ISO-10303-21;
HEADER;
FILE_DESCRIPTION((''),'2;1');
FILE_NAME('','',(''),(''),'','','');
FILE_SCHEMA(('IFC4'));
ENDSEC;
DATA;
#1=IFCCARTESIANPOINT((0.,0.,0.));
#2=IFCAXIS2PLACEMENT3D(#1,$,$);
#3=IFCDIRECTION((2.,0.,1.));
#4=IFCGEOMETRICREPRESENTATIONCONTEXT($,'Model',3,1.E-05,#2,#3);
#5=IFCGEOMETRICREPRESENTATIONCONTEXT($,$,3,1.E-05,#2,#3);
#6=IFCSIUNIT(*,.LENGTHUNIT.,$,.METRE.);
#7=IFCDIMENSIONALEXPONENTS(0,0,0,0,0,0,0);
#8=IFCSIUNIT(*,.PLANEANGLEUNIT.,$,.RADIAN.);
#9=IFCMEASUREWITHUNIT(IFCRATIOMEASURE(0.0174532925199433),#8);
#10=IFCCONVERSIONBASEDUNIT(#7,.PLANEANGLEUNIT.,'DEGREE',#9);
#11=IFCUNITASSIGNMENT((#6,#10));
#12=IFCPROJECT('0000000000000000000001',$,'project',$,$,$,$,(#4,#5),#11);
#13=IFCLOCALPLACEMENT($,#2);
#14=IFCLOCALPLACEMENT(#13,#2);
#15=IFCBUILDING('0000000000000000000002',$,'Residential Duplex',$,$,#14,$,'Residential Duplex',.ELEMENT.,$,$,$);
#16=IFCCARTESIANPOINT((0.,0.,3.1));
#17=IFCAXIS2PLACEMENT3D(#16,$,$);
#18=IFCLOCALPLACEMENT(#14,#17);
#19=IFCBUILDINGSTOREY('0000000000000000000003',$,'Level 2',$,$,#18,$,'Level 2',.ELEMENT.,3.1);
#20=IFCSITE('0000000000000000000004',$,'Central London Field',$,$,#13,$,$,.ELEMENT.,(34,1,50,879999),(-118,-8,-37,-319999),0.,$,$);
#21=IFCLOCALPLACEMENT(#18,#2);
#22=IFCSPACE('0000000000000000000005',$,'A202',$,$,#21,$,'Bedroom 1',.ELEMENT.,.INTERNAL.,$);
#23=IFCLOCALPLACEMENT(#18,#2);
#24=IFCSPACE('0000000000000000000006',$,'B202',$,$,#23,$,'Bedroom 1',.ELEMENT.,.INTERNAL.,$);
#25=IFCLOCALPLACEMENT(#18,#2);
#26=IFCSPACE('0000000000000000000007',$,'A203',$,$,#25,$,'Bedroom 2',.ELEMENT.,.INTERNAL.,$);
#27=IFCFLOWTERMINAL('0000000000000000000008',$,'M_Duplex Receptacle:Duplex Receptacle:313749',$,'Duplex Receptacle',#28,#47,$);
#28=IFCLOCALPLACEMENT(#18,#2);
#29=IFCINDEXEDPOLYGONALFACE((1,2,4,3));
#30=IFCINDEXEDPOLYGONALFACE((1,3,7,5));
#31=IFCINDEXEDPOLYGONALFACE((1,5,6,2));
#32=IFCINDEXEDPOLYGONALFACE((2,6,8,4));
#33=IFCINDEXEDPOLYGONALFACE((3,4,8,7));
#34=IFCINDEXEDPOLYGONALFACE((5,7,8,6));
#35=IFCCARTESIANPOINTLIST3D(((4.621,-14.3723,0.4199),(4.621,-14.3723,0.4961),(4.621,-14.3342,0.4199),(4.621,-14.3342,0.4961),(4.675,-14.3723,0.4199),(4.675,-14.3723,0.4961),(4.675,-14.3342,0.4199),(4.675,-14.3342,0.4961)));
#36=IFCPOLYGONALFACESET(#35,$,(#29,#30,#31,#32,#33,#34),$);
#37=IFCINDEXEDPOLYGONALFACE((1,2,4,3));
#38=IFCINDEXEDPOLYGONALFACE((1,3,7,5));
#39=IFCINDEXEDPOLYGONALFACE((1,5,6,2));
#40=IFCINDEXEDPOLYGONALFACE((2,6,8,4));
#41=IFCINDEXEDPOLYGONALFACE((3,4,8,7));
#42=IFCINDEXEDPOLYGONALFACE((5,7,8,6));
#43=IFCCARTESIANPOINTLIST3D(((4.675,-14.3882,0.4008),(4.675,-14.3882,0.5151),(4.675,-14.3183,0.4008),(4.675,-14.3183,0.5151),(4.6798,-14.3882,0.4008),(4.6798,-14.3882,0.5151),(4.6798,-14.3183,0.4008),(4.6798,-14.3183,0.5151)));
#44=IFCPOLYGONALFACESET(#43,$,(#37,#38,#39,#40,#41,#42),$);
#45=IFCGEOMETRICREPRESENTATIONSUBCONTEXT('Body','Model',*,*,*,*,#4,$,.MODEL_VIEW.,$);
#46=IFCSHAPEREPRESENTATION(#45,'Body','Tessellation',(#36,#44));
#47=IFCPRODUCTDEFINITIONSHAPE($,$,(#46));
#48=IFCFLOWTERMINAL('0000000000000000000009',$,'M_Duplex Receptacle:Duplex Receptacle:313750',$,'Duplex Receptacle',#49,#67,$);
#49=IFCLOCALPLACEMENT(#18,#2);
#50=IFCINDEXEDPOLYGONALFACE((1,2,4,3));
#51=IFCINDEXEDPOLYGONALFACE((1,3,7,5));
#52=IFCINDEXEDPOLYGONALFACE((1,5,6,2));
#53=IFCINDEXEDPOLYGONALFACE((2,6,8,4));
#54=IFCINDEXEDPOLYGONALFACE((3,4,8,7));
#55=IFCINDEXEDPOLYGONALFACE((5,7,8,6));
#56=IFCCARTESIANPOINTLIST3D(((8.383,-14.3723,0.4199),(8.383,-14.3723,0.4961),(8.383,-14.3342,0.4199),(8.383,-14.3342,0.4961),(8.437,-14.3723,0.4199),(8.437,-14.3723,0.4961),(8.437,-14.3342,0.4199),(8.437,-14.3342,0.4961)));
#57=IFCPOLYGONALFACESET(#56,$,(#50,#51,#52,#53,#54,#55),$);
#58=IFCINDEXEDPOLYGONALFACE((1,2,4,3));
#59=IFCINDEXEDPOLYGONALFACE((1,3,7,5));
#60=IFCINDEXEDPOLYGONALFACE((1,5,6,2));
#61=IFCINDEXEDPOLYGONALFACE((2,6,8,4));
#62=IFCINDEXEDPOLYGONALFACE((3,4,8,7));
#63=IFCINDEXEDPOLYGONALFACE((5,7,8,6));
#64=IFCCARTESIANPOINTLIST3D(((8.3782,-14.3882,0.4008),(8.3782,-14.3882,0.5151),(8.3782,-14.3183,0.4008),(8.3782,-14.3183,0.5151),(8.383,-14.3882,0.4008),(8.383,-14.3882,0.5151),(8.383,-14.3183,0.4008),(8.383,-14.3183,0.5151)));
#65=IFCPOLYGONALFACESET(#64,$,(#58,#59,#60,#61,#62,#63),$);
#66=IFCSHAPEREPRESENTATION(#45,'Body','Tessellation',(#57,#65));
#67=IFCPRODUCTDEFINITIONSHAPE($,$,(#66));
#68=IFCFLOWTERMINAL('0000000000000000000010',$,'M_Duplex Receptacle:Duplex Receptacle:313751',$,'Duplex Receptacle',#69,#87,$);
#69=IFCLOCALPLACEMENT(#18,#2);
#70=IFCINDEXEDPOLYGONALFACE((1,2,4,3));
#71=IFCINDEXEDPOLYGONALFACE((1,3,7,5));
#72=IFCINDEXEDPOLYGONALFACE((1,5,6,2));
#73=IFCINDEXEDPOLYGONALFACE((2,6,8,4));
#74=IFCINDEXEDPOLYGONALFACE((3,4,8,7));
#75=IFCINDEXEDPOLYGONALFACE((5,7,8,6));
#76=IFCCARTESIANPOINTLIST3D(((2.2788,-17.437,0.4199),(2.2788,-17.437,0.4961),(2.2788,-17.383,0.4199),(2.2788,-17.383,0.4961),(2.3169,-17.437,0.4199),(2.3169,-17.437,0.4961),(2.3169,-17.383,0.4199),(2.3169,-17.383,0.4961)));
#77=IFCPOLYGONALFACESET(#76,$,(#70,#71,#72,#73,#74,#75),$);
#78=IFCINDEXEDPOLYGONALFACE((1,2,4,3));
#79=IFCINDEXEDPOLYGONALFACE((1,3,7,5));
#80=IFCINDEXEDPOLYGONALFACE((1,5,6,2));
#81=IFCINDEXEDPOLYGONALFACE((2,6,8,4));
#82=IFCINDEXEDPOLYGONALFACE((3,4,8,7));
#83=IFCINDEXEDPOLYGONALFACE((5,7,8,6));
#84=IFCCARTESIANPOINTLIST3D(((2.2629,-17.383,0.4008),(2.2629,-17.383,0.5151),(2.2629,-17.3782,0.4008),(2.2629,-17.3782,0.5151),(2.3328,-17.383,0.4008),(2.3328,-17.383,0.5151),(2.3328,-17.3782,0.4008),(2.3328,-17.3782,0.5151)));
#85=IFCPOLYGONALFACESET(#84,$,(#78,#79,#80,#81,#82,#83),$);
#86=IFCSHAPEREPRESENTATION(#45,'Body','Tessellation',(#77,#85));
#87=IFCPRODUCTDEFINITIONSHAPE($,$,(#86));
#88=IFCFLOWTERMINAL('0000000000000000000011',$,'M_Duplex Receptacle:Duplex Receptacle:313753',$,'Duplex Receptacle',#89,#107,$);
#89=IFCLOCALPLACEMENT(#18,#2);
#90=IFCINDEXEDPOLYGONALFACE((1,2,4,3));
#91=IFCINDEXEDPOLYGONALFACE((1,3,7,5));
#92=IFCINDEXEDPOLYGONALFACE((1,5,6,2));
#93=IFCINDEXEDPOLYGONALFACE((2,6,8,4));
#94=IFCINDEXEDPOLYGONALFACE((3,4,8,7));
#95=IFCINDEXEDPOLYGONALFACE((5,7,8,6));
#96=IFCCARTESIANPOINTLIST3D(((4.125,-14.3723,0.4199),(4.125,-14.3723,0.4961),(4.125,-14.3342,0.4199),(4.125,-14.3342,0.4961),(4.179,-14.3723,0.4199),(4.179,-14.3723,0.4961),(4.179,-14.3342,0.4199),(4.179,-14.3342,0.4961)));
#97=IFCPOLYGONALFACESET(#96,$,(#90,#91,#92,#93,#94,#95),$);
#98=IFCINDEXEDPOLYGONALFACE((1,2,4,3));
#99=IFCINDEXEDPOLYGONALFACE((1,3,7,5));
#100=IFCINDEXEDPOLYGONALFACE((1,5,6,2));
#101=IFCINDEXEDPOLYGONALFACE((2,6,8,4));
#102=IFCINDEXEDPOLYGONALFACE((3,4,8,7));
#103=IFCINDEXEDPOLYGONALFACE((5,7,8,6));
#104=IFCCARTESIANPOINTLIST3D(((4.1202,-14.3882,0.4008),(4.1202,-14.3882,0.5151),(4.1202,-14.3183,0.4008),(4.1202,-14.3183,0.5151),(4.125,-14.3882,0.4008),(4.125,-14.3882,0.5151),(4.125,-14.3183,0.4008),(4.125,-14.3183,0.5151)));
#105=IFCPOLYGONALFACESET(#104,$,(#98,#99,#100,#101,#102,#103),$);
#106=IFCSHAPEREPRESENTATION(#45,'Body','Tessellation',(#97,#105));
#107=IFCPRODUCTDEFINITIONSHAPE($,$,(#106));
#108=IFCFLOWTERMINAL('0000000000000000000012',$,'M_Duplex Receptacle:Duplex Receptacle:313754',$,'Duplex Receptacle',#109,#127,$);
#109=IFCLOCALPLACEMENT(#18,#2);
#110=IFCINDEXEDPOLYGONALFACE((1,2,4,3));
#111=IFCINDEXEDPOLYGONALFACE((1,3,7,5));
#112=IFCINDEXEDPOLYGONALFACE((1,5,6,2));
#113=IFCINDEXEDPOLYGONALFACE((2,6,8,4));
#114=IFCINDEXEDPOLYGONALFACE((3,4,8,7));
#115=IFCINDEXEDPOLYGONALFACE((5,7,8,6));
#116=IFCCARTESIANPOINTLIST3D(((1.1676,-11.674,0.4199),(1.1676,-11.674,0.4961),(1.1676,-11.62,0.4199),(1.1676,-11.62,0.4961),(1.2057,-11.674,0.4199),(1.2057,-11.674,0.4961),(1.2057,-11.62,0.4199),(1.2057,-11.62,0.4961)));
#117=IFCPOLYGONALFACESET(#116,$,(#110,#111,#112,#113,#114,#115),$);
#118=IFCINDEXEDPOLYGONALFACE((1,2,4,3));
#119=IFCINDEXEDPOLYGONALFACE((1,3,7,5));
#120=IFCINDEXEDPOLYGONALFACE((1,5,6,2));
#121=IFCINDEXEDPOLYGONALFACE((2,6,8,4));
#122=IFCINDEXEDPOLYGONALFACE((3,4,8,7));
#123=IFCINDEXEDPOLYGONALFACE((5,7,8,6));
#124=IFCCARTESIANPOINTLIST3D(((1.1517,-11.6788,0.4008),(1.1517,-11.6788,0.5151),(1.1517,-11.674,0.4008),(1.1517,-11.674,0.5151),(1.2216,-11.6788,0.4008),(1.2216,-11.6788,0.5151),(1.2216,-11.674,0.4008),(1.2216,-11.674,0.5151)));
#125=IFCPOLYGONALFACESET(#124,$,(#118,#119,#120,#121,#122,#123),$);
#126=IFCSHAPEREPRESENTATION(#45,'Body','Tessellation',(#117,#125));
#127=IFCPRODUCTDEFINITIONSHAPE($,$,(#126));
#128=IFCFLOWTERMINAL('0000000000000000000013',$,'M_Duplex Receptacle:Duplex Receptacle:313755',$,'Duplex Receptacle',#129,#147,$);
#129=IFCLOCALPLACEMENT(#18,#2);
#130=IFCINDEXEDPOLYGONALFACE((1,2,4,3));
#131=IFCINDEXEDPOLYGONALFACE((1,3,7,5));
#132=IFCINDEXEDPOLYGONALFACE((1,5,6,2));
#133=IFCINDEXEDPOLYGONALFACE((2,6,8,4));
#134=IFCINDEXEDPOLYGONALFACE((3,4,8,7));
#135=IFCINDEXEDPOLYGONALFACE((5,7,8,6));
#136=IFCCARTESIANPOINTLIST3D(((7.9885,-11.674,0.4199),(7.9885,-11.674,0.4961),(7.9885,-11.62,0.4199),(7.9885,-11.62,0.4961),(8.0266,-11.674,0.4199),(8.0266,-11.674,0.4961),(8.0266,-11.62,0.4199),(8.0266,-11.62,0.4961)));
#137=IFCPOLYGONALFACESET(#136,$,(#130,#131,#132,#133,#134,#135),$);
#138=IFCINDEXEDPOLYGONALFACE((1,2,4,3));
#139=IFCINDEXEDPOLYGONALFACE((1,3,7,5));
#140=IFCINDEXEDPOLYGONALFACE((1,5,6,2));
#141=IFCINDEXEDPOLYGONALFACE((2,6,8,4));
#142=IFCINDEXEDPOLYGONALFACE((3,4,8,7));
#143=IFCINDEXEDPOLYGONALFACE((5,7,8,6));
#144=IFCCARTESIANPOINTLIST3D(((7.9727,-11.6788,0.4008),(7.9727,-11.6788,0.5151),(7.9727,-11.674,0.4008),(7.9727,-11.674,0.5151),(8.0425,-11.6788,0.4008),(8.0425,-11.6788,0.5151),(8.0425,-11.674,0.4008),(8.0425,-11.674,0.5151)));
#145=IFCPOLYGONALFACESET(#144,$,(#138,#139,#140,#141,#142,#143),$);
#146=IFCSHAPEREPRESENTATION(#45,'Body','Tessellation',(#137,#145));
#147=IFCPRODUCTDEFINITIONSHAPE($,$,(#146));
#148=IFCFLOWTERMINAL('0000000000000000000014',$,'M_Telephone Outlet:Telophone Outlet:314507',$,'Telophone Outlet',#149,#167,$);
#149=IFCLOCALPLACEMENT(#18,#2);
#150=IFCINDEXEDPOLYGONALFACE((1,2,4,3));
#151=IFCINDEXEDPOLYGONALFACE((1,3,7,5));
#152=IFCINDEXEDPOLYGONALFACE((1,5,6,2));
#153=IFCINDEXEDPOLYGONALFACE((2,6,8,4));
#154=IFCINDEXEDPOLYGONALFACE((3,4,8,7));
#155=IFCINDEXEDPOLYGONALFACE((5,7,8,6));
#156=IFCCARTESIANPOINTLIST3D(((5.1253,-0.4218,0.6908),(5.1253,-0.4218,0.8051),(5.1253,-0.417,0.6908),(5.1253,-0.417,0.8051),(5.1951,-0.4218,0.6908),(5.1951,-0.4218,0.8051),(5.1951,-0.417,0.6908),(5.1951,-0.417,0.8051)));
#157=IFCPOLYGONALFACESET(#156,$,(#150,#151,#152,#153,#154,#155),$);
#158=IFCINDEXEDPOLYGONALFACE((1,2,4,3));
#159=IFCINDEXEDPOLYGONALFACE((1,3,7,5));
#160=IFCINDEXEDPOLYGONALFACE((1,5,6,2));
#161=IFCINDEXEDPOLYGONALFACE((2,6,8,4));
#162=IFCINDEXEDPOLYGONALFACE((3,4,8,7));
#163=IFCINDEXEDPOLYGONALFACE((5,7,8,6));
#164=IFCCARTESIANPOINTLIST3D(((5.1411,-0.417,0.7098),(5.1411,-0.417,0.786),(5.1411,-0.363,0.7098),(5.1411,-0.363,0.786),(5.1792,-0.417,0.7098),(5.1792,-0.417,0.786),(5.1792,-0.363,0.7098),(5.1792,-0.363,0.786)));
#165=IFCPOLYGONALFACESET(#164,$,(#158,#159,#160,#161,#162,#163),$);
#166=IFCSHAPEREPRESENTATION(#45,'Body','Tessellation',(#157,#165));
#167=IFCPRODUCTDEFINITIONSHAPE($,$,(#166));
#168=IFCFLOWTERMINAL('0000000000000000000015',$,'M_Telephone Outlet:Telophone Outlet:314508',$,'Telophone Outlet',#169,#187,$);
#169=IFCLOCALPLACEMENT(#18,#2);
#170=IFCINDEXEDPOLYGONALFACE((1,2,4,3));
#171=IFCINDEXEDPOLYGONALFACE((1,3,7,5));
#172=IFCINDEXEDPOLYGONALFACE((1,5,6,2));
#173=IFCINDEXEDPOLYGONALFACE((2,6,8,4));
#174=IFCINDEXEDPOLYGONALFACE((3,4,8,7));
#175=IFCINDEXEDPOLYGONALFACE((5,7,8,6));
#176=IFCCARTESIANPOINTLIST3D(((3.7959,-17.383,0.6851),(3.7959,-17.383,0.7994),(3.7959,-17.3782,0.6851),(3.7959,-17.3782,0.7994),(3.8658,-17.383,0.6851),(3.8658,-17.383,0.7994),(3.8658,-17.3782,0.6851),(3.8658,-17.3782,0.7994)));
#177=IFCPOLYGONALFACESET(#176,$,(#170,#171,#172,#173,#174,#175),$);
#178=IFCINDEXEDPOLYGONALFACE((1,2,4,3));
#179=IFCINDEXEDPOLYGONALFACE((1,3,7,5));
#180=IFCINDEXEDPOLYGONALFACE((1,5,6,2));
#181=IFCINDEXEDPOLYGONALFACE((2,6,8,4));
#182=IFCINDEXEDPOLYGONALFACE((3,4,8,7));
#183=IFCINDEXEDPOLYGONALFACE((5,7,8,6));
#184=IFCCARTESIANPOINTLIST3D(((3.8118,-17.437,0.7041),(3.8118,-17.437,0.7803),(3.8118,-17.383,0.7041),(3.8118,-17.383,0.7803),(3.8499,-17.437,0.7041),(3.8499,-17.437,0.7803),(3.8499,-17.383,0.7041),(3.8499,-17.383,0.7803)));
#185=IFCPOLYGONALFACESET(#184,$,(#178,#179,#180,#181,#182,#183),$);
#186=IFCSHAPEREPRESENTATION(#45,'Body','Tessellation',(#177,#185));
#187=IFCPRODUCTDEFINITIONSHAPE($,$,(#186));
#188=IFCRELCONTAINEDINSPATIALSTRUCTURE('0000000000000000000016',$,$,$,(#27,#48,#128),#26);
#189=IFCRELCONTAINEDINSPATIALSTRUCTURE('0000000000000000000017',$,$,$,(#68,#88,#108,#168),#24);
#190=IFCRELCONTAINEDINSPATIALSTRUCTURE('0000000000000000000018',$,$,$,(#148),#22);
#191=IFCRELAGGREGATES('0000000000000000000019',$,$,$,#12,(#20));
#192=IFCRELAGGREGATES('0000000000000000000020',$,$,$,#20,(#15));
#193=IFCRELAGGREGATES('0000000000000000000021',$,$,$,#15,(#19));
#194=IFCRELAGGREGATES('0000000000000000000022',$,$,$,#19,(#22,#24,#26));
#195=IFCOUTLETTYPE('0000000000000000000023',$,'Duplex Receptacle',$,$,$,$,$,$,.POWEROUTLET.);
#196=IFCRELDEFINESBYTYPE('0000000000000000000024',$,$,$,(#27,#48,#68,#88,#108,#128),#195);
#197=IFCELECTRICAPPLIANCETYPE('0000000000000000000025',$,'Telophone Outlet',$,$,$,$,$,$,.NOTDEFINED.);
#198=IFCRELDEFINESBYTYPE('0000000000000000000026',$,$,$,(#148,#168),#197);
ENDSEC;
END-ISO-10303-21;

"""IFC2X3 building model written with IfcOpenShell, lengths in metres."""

from ifc_helpers import new_model, entity, si_unit, converted_unit, direction, frame, frame_2d, origin, origin_2d_with_axis, place, context, subcontext, project, spatial, rectangle, extrude, source, transform, mapped, type_object, type_shapes, element, save


model = new_model("IFC2X3")

# Units and contexts
model_context = context("Model", 3, precision=1e-05, world=origin(), true_north=direction((2.0, 0.0, 1.0)))
context_of_model = context(None, 3, precision=1e-05, world=origin(), true_north=direction((2.0, 0.0, 1.0)))
body_context = subcontext(model_context, "Body", "Model", "MODEL_VIEW")
ifc_project = project(units=[si_unit("LENGTHUNIT", "METRE"), converted_unit("PLANEANGLEUNIT", "DEGREE", entity("IfcRatioMeasure", 0.0174532925199433), si_unit("PLANEANGLEUNIT", "RADIAN"), dimensions=[0, 0, 0, 0, 0, 0, 0])], contexts=[model_context, context_of_model])

# Site, building, storey, space
site_placement = place(None, origin())
site = spatial("IfcSite", under=ifc_project, at=site_placement, Name="Central London Field", CompositionType="ELEMENT", RefLatitude=(34, 1, 50, 879999), RefLongitude=(-118, -8, -37, -319999), RefElevation=0.0)
building_placement = place(site_placement, origin())
building = spatial("IfcBuilding", under=site, at=building_placement, Name="Residential Duplex", LongName="Residential Duplex", CompositionType="ELEMENT")
storey_placement = place(building_placement, frame((0.0, 0.0, 3.1)))
storey = spatial("IfcBuildingStorey", under=building, at=storey_placement, Name="Level 2", LongName="Level 2", CompositionType="ELEMENT", Elevation=3.1)
space_1_placement = place(storey_placement, origin())
space_1 = spatial("IfcSpace", under=storey, at=space_1_placement, Name="A202", LongName="Bedroom 1", CompositionType="ELEMENT", InteriorOrExteriorSpace="INTERNAL")

# Shared definitions
space_2_placement = place(storey_placement, origin())
space_2 = spatial("IfcSpace", under=storey, at=space_2_placement, Name="B202", LongName="Bedroom 1", CompositionType="ELEMENT", InteriorOrExteriorSpace="INTERNAL")

# Shared definitions
space_3_placement = place(storey_placement, origin())
space_3 = spatial("IfcSpace", under=storey, at=space_3_placement, Name="A203", LongName="Bedroom 2", CompositionType="ELEMENT", InteriorOrExteriorSpace="INTERNAL")

# Flow terminals
outlet_type = type_object("IfcOutletType", Name="Duplex Receptacle", PredefinedType="POWEROUTLET")
shared_shape_1 = source(origin(), body_context, "Body", "SweptSolid", [
    extrude(rectangle(XDim=0.0381, YDim=0.0762, at=origin_2d_with_axis()), frame((0.0, 0.0, -0.054), z_axis=(0.0, 0.0, 1.0), x_axis=(-1.0, 0.0, 0.0)), (0.0, 0.0, 1.0), 0.054),
    extrude(rectangle(XDim=0.0698, YDim=0.1143, at=frame_2d((0.0, 0.0), x_axis=(1.0, 0.0))), frame((0.0, 0.0, 0.0), z_axis=(0.0, 0.0, 1.0), x_axis=(-1.0, 0.0, 0.0)), (0.0, 0.0, 1.0), 0.0048),
])
type_shapes(outlet_type, [shared_shape_1])
for number, where, z_axis, x_axis, name in (
    (1, (4.675, -14.3533, 0.458), (1.0, 0.0, 0.0), (0.0, 1.0, 0.0), "M_Duplex Receptacle:Duplex Receptacle:313749"),
    (2, (8.383, -14.3533, 0.458), (-1.0, 0.0, 0.0), (0.0, -1.0, 0.0), "M_Duplex Receptacle:Duplex Receptacle:313750"),
):
    element("IfcFlowTerminal", number, at=place(space_3_placement, frame(where, z_axis=z_axis, x_axis=x_axis)), inside=space_3, type_object=outlet_type, Name=name, ObjectType="Duplex Receptacle", context=body_context, shape_type="MappedRepresentation", body=[
        mapped(shared_shape_1, transform((0.0, 0.0, 0.0), scale=1.0)),
    ])
for number, where, z_axis, x_axis, name in (
    (3, (2.2979, -17.383, 0.458), (0.0, 1.0, 0.0), (-1.0, 0.0, 0.0), "M_Duplex Receptacle:Duplex Receptacle:313751"),
    (4, (4.125, -14.3533, 0.458), (-1.0, 0.0, 0.0), (0.0, -1.0, 0.0), "M_Duplex Receptacle:Duplex Receptacle:313753"),
    (5, (1.1866, -11.674, 0.458), (0.0, -1.0, 0.0), (1.0, 0.0, 0.0), "M_Duplex Receptacle:Duplex Receptacle:313754"),
):
    element("IfcFlowTerminal", number, at=place(space_2_placement, frame(where, z_axis=z_axis, x_axis=x_axis)), inside=space_2, type_object=outlet_type, Name=name, ObjectType="Duplex Receptacle", context=body_context, shape_type="MappedRepresentation", body=[
        mapped(shared_shape_1, transform((0.0, 0.0, 0.0), scale=1.0)),
    ])
flow_terminal_1_placement = place(space_3_placement, frame((8.0076, -11.674, 0.458), z_axis=(0.0, -1.0, 0.0), x_axis=(1.0, 0.0, 0.0)))
element("IfcFlowTerminal", 6, at=flow_terminal_1_placement, inside=space_3, type_object=outlet_type, Name="M_Duplex Receptacle:Duplex Receptacle:313755", ObjectType="Duplex Receptacle", context=body_context, shape_type="MappedRepresentation", body=[
    mapped(shared_shape_1, transform((0.0, 0.0, 0.0), scale=1.0)),
])
electric_appliance_type = type_object("IfcElectricApplianceType", Name="Telophone Outlet", PredefinedType="NOTDEFINED")
shared_shape_2 = source(origin(), body_context, "Body", "SweptSolid", [
    extrude(rectangle(XDim=0.0699, YDim=0.1143, at=frame_2d((0.0, 0.0), x_axis=(1.0, 0.0))), frame((0.0, 0.0, 0.0), z_axis=(0.0, 0.0, 1.0), x_axis=(-1.0, 0.0, 0.0)), (0.0, 0.0, 1.0), 0.0048),
    extrude(rectangle(XDim=0.0381, YDim=0.0762, at=origin_2d_with_axis()), frame((0.0, 0.0, -0.054), z_axis=(0.0, 0.0, 1.0), x_axis=(-1.0, 0.0, 0.0)), (0.0, 0.0, 1.0), 0.054),
])
type_shapes(electric_appliance_type, [shared_shape_2])
flow_terminal_2_placement = place(space_1_placement, frame((5.1602, -0.417, 0.7479), z_axis=(0.0, -1.0, 0.0), x_axis=(1.0, 0.0, 0.0)))
element("IfcFlowTerminal", 7, at=flow_terminal_2_placement, inside=space_1, type_object=electric_appliance_type, Name="M_Telephone Outlet:Telophone Outlet:314507", ObjectType="Telophone Outlet", context=body_context, shape_type="MappedRepresentation", body=[
    mapped(shared_shape_2, transform((0.0, 0.0, 0.0), scale=1.0)),
])
flow_terminal_3_placement = place(space_2_placement, frame((3.8309, -17.383, 0.7422), z_axis=(0.0, 1.0, 0.0), x_axis=(-1.0, 0.0, 0.0)))
element("IfcFlowTerminal", 8, at=flow_terminal_3_placement, inside=space_2, type_object=electric_appliance_type, Name="M_Telephone Outlet:Telophone Outlet:314508", ObjectType="Telophone Outlet", context=body_context, shape_type="MappedRepresentation", body=[
    mapped(shared_shape_2, transform((0.0, 0.0, 0.0), scale=1.0)),
])

save(model, "model.ifc")
